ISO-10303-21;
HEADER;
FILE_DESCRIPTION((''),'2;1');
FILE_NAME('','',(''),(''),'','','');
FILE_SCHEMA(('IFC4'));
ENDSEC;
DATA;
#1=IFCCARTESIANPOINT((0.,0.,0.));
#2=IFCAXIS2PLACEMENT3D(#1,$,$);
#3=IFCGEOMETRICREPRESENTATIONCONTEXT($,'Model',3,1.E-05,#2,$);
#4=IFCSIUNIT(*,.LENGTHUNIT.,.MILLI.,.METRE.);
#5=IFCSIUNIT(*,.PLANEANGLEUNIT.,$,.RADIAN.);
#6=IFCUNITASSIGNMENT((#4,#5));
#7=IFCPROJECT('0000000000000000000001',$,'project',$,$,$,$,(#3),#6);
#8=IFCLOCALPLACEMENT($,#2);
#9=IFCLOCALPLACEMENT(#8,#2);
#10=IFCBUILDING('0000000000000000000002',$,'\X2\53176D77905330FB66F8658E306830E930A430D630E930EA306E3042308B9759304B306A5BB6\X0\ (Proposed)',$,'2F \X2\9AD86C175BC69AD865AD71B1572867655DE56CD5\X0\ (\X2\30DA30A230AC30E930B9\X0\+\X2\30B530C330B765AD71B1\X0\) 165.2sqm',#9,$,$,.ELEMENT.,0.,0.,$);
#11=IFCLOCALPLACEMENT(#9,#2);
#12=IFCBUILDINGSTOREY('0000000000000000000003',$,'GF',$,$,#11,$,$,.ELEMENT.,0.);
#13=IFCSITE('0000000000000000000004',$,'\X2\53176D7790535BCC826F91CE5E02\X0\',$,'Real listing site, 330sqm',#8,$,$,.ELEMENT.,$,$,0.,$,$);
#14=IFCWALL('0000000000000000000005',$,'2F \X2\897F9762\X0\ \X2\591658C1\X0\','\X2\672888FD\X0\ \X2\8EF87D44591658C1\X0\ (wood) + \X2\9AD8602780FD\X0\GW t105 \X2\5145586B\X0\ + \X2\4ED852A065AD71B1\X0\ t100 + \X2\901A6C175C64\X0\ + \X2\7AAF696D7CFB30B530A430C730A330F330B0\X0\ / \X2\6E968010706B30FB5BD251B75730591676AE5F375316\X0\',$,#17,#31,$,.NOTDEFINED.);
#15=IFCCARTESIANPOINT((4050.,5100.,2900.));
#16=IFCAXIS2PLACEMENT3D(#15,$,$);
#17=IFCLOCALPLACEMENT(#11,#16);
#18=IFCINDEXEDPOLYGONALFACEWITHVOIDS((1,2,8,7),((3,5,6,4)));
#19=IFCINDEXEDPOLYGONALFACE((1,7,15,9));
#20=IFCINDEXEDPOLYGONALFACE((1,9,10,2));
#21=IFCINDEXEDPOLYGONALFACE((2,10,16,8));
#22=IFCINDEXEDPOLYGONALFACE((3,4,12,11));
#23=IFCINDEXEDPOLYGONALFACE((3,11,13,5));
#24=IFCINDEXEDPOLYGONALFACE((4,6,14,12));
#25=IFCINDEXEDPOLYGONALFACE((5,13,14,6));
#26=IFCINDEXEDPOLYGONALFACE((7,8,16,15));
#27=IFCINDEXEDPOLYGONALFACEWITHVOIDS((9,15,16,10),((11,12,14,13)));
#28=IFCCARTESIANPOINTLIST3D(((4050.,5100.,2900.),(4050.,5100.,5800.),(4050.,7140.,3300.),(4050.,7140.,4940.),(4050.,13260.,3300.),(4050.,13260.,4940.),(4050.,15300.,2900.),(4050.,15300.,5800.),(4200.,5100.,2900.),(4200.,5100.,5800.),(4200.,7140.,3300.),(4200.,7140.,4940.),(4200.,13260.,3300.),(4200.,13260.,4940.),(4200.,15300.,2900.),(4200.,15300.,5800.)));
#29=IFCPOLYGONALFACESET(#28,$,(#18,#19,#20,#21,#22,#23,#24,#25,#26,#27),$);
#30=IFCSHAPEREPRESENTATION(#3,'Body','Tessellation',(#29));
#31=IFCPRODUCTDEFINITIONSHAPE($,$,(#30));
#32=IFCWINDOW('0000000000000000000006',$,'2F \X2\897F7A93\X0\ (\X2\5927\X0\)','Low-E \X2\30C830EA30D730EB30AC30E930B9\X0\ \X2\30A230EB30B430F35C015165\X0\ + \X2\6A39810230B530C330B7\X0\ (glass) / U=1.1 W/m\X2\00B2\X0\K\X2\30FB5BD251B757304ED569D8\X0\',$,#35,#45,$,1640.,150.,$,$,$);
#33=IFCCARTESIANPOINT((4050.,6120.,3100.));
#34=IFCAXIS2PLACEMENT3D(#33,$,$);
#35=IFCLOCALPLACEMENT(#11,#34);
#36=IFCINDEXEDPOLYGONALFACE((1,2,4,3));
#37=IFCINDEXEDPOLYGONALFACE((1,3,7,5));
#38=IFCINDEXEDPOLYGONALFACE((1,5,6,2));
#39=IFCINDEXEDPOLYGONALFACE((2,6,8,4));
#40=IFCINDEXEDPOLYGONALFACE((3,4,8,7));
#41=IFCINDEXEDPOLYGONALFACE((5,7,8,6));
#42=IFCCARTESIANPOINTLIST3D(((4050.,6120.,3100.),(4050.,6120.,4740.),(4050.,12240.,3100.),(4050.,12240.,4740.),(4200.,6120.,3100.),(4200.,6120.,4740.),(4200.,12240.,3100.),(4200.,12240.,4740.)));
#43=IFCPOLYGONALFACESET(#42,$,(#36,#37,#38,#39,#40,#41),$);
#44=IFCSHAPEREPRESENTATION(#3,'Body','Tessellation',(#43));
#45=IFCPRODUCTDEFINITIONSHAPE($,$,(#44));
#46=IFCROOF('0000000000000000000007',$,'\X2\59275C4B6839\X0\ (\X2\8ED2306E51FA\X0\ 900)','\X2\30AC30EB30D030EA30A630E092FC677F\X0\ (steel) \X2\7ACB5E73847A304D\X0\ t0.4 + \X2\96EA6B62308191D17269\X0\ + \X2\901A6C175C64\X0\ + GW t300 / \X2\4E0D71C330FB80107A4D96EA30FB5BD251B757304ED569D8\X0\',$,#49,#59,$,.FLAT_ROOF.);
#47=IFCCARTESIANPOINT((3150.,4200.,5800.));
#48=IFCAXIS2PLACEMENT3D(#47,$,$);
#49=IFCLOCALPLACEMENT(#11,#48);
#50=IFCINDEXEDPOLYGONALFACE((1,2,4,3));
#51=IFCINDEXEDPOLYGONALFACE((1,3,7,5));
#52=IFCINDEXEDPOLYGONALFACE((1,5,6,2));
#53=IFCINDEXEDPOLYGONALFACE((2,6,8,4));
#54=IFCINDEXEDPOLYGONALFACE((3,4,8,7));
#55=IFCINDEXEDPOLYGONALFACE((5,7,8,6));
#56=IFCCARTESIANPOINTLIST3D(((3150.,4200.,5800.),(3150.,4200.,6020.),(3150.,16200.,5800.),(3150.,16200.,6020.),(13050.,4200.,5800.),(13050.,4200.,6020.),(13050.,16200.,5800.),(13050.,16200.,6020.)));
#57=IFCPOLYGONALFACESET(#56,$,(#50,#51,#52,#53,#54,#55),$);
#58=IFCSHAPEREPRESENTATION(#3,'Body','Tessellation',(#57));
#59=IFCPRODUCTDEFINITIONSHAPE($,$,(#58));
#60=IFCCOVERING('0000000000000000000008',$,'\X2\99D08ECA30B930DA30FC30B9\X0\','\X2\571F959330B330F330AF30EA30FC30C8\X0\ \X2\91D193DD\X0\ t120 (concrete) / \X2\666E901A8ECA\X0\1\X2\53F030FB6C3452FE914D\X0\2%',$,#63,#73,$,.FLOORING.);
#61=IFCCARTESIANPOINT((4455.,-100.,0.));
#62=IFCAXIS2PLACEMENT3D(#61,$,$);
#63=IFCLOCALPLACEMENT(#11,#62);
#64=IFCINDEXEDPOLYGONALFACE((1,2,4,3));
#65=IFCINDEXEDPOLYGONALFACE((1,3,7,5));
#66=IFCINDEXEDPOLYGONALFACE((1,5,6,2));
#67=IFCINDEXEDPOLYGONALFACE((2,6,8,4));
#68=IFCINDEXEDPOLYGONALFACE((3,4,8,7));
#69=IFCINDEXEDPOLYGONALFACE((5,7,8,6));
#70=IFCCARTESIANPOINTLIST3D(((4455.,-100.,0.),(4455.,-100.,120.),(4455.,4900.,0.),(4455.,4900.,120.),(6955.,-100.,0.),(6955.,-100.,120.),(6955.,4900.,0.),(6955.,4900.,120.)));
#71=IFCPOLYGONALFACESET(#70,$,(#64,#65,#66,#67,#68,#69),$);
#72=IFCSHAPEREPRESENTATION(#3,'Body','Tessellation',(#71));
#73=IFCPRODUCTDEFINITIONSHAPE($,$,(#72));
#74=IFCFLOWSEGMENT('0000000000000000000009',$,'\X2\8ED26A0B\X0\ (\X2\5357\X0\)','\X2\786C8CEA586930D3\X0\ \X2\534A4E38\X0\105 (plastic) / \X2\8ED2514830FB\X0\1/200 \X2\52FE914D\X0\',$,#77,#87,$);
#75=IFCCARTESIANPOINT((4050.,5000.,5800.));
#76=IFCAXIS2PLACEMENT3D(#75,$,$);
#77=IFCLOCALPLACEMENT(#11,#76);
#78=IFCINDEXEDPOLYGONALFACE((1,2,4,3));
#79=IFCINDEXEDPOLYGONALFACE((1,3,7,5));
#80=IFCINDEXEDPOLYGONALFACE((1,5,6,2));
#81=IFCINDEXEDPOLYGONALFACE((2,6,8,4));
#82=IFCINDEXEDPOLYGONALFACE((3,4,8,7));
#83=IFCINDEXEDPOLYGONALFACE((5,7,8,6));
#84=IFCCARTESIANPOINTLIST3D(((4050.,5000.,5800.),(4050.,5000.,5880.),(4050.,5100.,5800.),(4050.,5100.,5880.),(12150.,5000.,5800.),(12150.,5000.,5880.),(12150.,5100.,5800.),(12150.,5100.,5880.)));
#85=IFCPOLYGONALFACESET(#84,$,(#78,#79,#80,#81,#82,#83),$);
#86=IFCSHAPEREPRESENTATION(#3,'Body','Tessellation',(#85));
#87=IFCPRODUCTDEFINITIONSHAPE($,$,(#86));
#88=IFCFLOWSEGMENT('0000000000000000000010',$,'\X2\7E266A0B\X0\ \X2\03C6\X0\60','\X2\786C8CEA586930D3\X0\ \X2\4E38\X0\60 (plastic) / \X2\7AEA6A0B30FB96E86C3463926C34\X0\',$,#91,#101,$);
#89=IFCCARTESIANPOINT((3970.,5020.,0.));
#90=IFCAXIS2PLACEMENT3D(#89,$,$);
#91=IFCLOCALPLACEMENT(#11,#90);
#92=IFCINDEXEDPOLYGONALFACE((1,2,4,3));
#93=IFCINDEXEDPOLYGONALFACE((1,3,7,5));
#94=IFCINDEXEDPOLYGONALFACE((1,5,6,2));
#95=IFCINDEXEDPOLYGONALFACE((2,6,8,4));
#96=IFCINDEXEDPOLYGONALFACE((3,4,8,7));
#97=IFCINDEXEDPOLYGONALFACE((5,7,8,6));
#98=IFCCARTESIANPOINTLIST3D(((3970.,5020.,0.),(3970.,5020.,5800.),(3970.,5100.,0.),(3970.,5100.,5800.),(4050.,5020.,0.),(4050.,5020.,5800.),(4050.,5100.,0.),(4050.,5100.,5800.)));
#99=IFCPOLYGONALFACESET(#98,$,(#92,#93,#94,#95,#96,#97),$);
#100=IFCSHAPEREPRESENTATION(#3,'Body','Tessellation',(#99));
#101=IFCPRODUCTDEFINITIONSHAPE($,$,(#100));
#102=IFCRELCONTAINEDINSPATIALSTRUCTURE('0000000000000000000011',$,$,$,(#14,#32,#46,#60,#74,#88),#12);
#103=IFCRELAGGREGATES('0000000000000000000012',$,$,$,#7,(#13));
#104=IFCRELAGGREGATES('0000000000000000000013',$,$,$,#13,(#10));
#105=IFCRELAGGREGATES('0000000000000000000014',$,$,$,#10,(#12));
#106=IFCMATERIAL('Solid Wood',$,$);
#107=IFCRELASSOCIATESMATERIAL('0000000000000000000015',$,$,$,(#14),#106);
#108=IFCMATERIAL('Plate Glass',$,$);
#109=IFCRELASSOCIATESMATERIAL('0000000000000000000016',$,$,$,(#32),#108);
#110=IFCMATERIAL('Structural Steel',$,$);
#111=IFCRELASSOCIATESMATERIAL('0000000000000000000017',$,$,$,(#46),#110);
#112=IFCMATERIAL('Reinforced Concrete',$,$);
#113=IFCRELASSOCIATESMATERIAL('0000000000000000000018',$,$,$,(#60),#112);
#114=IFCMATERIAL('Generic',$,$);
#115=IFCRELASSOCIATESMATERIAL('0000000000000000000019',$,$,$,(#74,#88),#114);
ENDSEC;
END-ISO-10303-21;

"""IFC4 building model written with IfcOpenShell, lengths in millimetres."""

from ifc_helpers import new_model, si_unit, frame, frame_2d, origin, place, context, project, spatial, rectangle, extrude, material, element, fill, save


model = new_model("IFC4")

# Units and contexts
model_context = context("Model", 3, precision=1e-05, world=origin())
ifc_project = project(units=[si_unit("LENGTHUNIT", "METRE", prefix="MILLI"), si_unit("PLANEANGLEUNIT", "RADIAN")], contexts=[model_context])

# Site, building, storey
site_placement = place(None, origin())
site = spatial("IfcSite", under=ifc_project, at=site_placement, Name="北海道富良野市", ObjectType="Real listing site, 330sqm", CompositionType="ELEMENT", RefElevation=0.0)
building_placement = place(site_placement, origin())
building = spatial("IfcBuilding", under=site, at=building_placement, Name="北海道・書斎とライブラリのある静かな家 (Proposed)", ObjectType="2F 高気密高断熱在来工法 (ペアガラス+サッシ断熱) 165.2sqm", CompositionType="ELEMENT", ElevationOfRefHeight=0.0, ElevationOfTerrain=0.0)
storey_placement = place(building_placement, origin())
storey = spatial("IfcBuildingStorey", under=building, at=storey_placement, Name="GF", CompositionType="ELEMENT", Elevation=0.0)

# Shared definitions
ifc_material_1 = material(Name="Solid Wood")

# Shared definitions
ifc_material_2 = material(Name="Reinforced Concrete")

# Shared definitions
ifc_material_3 = material(Name="Plate Glass")

# Wall, opening, window
wall_1_placement = place(storey_placement, frame((4050.0, 5100.0, 2900.0)))
wall_1 = element("IfcWall", 1, at=wall_1_placement, inside=storey, material=ifc_material_1, Name="2F 西面 外壁", Description="木製 軸組外壁 (wood) + 高性能GW t105 充填 + 付加断熱 t100 + 通気層 + 窯業系サイディング / 準耐火・寒冷地外皮強化", PredefinedType="NOTDEFINED", context=model_context, shape_type="SweptSolid", body=[
    extrude(rectangle(XDim=150.0, YDim=10200.0, at=frame_2d((75.0, 5100.0))), frame((4050.0, 5100.0, 2900.0)), (0.0, 0.0, 1.0), 2900.0),
])
opening_1_placement = place(storey_placement, frame((4050.0, 6120.0, 3100.0)))
opening_1 = element("IfcOpeningElement", 2, at=opening_1_placement, cuts=wall_1, PredefinedType="NOTDEFINED", context=model_context, shape_type="SweptSolid", body=[
    extrude(rectangle(XDim=150.0, YDim=6120.0, at=frame_2d((75.0, 3060.0))), frame((4050.0, 6120.0, 3100.0)), (0.0, 0.0, 1.0), 1640.0),
])
window_1_placement = place(storey_placement, frame((4050.0, 6120.0, 3100.0)))
window_1 = element("IfcWindow", 3, at=window_1_placement, inside=storey, material=ifc_material_3, Name="2F 西窓 (大)", Description="Low-E トリプルガラス アルゴン封入 + 樹脂サッシ (glass) / U=1.1 W/m²K・寒冷地仕様", OverallHeight=1640.0, OverallWidth=150.0, context=model_context, shape_type="SweptSolid", body=[
    extrude(rectangle(XDim=150.0, YDim=6120.0, at=frame_2d((75.0, 3060.0))), frame((4050.0, 6120.0, 3100.0)), (0.0, 0.0, 1.0), 1640.0),
])
fill(opening_1, window_1)

# Roof
ifc_material_4 = material(Name="Structural Steel")
roof_placement = place(storey_placement, frame((3150.0, 4200.0, 5800.0)))
element("IfcRoof", 4, at=roof_placement, inside=storey, material=ifc_material_4, Name="大屋根 (軒の出 900)", Description="ガルバリウム鋼板 (steel) 立平葺き t0.4 + 雪止め金物 + 通気層 + GW t300 / 不燃・耐積雪・寒冷地仕様", PredefinedType="FLAT_ROOF", context=model_context, shape_type="SweptSolid", body=[
    extrude(rectangle(XDim=9900.0, YDim=12000.0, at=frame_2d((4950.0, 6000.0))), frame((3150.0, 4200.0, 5800.0)), (0.0, 0.0, 1.0), 220.0),
])

# Covering
covering_placement = place(storey_placement, frame((4455.0, -100.0, 0.0)))
element("IfcCovering", 5, at=covering_placement, inside=storey, material=ifc_material_2, Name="駐車スペース", Description="土間コンクリート 金鏝 t120 (concrete) / 普通車1台・水勾配2%", PredefinedType="FLOORING", context=model_context, shape_type="SweptSolid", body=[
    extrude(rectangle(XDim=2500.0, YDim=5000.0, at=frame_2d((1250.0, 2500.0))), frame((4455.0, -100.0, 0.0)), (0.0, 0.0, 1.0), 120.0),
])

# Flow segments
ifc_material_5 = material(Name="Generic")
flow_segment_1_placement = place(storey_placement, frame((4050.0, 5000.0, 5800.0)))
element("IfcFlowSegment", 6, at=flow_segment_1_placement, inside=storey, material=ifc_material_5, Name="軒樋 (南)", Description="硬質塩ビ 半丸105 (plastic) / 軒先・1/200 勾配", context=model_context, shape_type="SweptSolid", body=[
    extrude(rectangle(XDim=8100.0, YDim=100.0, at=frame_2d((4050.0, 50.0))), frame((4050.0, 5000.0, 5800.0)), (0.0, 0.0, 1.0), 80.0),
])
flow_segment_2_placement = place(storey_placement, frame((3970.0, 5020.0, 0.0)))
element("IfcFlowSegment", 7, at=flow_segment_2_placement, inside=storey, material=ifc_material_5, Name="縦樋 φ60", Description="硬質塩ビ 丸60 (plastic) / 竪樋・雨水排水", context=model_context, shape_type="SweptSolid", body=[
    extrude(rectangle(XDim=80.0, YDim=80.0, at=frame_2d((40.0, 40.0))), frame((3970.0, 5020.0, 0.0)), (0.0, 0.0, 1.0), 5800.0),
])

save(model, "model.ifc")
